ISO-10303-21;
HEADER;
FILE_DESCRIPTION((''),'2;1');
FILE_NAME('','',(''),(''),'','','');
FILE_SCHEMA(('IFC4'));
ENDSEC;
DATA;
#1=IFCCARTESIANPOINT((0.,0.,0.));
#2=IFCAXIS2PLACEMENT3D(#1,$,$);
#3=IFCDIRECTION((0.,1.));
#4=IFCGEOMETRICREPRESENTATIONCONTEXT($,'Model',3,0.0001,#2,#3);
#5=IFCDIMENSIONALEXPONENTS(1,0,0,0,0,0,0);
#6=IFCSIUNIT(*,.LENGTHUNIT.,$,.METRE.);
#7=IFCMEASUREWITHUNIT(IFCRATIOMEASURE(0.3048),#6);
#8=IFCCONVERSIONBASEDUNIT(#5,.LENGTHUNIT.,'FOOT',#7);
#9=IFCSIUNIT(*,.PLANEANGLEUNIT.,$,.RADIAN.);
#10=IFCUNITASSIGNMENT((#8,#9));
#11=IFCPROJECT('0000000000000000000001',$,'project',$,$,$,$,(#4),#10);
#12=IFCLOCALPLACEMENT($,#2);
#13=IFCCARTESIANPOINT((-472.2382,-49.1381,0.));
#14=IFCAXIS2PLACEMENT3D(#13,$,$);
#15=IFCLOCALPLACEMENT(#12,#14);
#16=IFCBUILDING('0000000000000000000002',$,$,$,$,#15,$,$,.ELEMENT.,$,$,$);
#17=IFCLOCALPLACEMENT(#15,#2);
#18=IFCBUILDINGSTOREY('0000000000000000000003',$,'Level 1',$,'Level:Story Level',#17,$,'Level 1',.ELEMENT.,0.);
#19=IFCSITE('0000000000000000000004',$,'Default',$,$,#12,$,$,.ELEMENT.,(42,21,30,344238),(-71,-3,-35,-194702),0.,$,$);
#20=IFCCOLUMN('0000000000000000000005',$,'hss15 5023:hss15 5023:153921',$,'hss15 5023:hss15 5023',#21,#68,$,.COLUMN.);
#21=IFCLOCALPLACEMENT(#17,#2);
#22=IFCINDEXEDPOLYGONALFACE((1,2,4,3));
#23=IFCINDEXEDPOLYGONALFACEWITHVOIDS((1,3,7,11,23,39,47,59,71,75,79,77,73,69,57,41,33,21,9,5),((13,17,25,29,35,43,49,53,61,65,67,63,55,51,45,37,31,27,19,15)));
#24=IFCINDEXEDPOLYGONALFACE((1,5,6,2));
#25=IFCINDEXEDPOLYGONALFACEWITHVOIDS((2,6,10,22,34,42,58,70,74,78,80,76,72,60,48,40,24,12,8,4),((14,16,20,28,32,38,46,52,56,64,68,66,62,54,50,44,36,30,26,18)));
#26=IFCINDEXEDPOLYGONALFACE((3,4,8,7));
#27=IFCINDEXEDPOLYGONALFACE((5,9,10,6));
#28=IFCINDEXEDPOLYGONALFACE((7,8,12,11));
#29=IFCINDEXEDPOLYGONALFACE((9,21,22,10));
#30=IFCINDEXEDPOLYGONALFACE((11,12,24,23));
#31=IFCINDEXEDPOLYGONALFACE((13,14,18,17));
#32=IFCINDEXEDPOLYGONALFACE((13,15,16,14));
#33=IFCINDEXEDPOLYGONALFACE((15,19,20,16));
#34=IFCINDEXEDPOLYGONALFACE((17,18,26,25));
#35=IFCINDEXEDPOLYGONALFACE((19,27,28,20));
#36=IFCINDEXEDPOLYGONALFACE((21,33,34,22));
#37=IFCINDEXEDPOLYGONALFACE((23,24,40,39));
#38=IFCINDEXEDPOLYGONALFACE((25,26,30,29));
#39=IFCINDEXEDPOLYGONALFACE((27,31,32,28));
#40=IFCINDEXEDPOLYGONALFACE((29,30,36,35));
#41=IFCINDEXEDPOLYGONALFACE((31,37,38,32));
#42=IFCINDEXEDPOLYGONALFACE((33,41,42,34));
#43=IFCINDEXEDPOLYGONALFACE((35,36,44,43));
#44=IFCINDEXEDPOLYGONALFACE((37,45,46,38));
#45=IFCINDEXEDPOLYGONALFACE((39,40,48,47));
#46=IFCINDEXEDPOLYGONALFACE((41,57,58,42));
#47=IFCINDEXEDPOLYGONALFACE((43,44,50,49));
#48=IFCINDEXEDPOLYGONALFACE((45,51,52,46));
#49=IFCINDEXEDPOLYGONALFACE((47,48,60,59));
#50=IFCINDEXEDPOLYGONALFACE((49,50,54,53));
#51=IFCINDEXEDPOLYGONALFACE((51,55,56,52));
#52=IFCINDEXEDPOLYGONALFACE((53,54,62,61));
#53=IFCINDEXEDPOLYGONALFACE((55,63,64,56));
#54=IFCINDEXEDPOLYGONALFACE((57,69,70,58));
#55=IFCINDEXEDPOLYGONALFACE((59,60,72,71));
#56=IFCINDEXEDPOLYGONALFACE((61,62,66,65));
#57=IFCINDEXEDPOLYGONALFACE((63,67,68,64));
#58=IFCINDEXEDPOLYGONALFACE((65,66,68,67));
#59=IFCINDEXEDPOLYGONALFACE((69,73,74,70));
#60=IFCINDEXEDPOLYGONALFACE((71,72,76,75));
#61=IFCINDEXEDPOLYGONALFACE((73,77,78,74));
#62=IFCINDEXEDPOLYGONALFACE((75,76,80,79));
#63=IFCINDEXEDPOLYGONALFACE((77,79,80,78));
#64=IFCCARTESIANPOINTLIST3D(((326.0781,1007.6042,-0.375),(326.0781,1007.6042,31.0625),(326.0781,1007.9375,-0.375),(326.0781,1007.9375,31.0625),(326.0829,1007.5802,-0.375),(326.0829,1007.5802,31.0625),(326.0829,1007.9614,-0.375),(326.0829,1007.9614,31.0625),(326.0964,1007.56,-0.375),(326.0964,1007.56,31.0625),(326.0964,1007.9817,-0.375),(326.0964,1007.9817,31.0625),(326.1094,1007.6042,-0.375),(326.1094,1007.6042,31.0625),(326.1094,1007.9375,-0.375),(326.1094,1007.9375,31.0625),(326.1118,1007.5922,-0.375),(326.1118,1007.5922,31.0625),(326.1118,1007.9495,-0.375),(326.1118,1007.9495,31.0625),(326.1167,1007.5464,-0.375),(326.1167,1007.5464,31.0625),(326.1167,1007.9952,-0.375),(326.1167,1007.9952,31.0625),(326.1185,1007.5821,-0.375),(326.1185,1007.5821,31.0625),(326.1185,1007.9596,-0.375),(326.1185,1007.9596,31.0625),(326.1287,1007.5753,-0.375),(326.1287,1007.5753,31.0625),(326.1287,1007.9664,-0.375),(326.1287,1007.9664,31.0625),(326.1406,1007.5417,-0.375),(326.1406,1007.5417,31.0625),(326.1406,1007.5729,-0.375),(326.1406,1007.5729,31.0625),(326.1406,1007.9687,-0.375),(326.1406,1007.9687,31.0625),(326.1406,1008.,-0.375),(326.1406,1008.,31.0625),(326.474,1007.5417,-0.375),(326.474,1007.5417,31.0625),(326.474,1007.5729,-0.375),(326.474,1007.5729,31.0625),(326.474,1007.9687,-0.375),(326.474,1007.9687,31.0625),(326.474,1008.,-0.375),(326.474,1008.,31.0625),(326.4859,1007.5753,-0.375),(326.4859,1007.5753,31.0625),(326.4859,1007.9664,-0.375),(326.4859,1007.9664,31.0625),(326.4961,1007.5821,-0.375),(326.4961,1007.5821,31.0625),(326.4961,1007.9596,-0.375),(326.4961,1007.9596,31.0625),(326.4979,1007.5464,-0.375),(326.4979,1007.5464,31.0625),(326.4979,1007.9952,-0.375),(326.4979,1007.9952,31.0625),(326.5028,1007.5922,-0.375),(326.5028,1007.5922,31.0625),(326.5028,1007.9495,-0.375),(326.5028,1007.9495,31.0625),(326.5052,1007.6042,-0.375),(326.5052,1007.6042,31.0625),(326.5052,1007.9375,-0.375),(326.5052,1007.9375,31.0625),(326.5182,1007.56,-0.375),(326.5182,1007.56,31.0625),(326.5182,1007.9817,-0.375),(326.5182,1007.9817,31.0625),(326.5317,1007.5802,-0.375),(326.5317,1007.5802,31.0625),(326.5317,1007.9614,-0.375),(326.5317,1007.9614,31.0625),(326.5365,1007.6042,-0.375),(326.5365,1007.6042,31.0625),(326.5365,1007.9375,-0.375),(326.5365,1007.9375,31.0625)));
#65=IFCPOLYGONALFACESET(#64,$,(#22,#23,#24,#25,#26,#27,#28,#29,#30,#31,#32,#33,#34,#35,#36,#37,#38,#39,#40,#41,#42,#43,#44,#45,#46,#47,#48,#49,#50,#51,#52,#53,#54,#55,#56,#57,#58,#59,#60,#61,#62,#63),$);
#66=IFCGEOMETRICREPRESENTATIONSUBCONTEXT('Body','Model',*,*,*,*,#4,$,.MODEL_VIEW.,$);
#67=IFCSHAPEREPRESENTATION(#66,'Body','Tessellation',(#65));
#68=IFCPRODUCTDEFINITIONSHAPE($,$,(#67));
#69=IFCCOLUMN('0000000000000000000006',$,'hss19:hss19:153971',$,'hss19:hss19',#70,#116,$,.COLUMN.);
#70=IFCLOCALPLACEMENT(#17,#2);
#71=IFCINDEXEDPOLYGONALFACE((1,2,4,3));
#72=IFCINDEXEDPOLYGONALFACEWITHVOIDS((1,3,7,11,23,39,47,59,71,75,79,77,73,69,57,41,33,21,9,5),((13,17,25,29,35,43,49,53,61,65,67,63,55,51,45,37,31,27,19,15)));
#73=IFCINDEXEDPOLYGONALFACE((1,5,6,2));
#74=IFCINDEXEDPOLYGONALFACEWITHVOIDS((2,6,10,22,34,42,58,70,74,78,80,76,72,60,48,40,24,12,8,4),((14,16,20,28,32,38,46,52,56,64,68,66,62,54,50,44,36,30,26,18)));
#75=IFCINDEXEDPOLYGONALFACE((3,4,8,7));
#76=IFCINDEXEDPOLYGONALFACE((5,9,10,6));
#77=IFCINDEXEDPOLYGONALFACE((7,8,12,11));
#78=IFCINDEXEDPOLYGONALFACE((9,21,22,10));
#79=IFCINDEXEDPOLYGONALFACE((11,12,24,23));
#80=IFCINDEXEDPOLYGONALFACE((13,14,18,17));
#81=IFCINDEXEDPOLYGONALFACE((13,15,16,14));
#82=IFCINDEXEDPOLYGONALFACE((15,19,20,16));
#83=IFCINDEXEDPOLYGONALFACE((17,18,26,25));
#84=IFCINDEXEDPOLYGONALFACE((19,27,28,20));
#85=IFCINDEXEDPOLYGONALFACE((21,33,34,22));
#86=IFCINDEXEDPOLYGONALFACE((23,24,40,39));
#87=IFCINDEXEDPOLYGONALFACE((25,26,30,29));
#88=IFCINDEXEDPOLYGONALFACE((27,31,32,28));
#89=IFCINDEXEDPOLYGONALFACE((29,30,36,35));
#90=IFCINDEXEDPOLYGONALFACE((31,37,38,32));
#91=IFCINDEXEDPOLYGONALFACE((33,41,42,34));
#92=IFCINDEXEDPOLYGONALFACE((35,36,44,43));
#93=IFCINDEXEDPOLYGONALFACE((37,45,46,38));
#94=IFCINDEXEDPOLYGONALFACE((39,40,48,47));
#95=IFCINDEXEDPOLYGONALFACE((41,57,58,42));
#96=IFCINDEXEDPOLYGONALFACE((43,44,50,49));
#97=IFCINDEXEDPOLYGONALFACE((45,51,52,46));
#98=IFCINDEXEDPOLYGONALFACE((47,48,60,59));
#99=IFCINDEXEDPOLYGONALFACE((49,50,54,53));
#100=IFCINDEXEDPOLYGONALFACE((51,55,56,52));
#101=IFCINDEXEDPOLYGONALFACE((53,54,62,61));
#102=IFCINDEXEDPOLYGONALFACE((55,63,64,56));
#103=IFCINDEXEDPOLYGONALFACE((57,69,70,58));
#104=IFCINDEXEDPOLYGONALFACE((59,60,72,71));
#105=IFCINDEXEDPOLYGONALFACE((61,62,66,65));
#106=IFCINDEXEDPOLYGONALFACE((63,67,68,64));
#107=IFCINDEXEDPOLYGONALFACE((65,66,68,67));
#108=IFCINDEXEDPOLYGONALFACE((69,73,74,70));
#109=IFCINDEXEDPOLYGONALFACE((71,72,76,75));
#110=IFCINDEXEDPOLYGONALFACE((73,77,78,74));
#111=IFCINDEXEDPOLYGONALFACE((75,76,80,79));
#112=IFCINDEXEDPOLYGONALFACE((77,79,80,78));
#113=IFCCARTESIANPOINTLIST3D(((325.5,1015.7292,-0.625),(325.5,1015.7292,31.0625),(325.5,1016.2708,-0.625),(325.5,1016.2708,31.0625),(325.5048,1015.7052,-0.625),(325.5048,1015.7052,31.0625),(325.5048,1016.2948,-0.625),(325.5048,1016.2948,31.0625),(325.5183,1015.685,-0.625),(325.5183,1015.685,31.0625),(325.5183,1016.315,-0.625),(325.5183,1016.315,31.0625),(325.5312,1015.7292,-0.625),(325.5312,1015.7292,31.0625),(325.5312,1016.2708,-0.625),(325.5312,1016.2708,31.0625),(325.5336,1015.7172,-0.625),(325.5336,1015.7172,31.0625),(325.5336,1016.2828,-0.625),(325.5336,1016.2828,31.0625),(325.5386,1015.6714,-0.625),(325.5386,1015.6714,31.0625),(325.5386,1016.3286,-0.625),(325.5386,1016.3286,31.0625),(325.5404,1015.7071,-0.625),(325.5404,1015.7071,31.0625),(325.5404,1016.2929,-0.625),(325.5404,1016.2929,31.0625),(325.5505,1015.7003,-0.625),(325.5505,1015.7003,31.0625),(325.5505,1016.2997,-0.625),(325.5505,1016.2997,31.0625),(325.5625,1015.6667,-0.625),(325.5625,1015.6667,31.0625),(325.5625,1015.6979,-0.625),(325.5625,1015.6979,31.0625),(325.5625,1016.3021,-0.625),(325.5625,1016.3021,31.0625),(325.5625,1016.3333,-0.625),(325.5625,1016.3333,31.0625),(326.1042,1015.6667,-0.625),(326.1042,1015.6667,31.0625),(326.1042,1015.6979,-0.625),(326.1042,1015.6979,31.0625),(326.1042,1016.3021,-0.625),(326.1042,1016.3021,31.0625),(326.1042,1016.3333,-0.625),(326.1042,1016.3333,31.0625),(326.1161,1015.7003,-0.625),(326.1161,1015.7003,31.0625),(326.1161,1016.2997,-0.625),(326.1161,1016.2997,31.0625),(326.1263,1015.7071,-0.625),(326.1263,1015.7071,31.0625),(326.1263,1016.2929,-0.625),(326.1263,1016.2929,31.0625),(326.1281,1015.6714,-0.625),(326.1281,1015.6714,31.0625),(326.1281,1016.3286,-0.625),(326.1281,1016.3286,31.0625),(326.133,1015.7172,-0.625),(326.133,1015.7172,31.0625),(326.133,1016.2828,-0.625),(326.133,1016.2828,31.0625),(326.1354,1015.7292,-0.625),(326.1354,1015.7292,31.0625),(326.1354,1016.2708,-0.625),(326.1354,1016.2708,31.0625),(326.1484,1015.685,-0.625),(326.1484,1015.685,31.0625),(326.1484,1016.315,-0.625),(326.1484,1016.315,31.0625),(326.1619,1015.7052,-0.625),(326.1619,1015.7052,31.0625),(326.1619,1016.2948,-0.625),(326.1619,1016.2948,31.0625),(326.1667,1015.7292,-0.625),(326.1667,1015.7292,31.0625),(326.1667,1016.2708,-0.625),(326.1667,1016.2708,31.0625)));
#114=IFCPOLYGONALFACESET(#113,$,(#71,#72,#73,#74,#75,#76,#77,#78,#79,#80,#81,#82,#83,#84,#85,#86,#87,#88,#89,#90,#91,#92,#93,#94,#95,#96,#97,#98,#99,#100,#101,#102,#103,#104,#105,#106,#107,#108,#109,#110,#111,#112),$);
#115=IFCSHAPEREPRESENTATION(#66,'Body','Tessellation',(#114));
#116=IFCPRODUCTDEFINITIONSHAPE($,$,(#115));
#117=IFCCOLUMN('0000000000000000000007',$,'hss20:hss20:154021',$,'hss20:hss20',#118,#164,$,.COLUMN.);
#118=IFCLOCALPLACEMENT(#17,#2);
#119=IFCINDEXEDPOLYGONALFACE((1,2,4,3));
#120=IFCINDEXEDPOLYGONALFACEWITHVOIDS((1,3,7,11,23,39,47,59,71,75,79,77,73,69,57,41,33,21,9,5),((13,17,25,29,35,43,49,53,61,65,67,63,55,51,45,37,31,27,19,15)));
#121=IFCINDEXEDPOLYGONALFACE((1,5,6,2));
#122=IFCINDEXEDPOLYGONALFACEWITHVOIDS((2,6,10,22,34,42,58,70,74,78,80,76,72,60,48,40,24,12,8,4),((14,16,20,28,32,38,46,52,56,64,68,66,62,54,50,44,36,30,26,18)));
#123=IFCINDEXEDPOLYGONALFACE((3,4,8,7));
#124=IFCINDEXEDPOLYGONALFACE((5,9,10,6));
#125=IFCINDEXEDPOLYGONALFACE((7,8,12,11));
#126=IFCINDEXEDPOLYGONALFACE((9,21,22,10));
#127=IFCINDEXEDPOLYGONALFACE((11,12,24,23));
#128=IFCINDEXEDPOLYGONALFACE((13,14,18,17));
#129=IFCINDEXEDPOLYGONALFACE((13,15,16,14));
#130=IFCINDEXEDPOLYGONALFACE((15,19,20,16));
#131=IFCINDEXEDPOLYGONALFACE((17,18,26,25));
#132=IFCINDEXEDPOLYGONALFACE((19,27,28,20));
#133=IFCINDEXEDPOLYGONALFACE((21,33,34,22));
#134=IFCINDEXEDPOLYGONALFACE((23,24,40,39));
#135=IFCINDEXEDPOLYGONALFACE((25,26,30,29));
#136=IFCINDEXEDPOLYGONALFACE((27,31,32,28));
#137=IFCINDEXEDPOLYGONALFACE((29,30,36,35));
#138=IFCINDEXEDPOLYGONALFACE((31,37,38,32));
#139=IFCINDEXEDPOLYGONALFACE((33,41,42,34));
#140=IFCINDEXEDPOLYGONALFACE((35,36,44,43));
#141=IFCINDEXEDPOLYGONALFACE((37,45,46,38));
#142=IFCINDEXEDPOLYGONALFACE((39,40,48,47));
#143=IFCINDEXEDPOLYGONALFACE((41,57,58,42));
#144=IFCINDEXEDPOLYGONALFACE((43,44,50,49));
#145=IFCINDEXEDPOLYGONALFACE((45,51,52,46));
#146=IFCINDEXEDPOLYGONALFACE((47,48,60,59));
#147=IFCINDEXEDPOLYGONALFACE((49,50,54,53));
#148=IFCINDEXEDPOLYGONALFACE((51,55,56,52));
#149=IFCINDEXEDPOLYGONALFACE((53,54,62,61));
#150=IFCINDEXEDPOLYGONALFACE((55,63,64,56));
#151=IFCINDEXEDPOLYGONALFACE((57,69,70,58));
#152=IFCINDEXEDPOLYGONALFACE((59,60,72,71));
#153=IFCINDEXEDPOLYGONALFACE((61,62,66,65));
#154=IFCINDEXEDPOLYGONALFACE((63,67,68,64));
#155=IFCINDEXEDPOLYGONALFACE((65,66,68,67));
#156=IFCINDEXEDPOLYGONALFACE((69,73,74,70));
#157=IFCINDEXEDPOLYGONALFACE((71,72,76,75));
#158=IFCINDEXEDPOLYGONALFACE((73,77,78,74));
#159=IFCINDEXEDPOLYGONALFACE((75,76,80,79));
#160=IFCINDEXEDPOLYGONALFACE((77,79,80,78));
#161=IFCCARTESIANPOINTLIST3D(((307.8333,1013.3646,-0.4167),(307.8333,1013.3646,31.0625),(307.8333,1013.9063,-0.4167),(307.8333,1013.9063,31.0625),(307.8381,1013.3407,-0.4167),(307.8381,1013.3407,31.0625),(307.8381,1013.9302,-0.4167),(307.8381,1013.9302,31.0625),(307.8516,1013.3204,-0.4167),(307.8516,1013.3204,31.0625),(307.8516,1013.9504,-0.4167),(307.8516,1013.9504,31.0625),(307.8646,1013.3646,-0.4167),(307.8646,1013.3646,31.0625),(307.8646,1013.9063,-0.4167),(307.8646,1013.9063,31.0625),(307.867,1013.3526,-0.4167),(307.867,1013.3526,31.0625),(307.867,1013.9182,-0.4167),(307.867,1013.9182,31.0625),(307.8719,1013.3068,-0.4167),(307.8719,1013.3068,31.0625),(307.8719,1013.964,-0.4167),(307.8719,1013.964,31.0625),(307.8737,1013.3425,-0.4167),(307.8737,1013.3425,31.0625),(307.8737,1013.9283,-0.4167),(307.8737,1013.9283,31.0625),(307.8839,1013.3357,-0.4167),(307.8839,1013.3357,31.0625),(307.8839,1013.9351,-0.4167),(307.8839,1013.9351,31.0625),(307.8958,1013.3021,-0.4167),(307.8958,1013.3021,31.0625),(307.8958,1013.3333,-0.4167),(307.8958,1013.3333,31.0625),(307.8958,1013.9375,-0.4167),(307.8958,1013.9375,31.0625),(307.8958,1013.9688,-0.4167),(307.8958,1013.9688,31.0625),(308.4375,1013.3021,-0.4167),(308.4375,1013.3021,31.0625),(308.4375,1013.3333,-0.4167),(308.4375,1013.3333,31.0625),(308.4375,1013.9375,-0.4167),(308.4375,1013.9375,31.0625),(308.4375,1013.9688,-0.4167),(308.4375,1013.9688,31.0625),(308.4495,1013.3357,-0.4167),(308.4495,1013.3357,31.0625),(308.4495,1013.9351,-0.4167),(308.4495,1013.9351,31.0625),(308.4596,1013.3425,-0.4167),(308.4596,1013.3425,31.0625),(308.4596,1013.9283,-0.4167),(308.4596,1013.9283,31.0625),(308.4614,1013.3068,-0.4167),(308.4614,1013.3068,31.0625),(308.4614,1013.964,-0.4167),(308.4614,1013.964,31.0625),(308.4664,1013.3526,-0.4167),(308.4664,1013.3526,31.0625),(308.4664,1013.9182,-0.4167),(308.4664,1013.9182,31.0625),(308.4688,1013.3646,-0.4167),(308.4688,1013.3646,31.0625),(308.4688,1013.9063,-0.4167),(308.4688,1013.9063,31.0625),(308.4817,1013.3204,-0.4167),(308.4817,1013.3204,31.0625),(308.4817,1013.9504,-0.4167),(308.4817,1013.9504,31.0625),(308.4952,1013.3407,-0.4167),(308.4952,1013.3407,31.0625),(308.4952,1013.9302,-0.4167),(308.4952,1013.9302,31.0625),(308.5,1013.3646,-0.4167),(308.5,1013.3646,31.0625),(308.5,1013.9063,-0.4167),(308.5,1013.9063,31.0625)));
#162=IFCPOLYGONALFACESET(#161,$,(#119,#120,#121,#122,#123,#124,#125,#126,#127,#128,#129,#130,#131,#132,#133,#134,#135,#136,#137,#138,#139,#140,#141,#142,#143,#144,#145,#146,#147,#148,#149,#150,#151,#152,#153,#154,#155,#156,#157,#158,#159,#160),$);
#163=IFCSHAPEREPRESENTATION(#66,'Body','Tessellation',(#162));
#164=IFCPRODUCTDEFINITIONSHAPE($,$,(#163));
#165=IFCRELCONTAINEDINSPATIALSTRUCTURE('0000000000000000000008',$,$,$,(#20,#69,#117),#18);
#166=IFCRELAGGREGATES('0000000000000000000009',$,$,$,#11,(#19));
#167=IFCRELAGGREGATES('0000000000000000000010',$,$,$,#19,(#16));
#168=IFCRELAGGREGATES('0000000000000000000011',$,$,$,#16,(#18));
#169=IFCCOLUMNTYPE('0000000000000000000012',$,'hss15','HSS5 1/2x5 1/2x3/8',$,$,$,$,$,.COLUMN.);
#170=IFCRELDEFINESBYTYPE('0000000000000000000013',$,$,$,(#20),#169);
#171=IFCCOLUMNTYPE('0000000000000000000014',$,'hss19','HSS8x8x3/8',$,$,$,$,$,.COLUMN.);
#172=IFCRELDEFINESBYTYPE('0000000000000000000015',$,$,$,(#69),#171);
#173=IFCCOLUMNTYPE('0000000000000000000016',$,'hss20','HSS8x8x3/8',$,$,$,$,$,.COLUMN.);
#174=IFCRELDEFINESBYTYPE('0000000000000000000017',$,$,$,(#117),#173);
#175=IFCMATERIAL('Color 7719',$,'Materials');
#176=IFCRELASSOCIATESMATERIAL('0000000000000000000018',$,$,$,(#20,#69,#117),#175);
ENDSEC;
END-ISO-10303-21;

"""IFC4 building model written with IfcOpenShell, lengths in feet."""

from ifc_helpers import new_model, entity, si_unit, converted_unit, direction, frame, origin, place, context, subcontext, project, spatial, polyline, outline, extrude, boolean, source, transform, mapped, material, type_object, type_shapes, element, save


model = new_model("IFC4")

# Units and contexts
model_context = context("Model", 3, precision=0.0001, world=origin(), true_north=direction((0.0, 1.0)))
body_context = subcontext(model_context, "Body", "Model", "MODEL_VIEW")
ifc_project = project(units=[converted_unit("LENGTHUNIT", "FOOT", entity("IfcRatioMeasure", 0.3048), si_unit("LENGTHUNIT", "METRE"), dimensions=[1, 0, 0, 0, 0, 0, 0]), si_unit("PLANEANGLEUNIT", "RADIAN")], contexts=[model_context])

# Site, building, storey
site_placement = place(None, origin())
site = spatial("IfcSite", under=ifc_project, at=site_placement, Name="Default", CompositionType="ELEMENT", RefLatitude=(42, 21, 30, 344238), RefLongitude=(-71, -3, -35, -194702), RefElevation=0.0)
building_placement = place(site_placement, frame((-472.2382, -49.1381, 0.0)))
building = spatial("IfcBuilding", under=site, at=building_placement, CompositionType="ELEMENT")
storey_placement = place(building_placement, origin())
storey = spatial("IfcBuildingStorey", under=building, at=storey_placement, Name="Level 1", ObjectType="Level:Story Level", LongName="Level 1", CompositionType="ELEMENT", Elevation=0.0)

# Columns
ifc_material_1 = material(Name="Color 7719", Category="Materials")
column_type_1 = type_object("IfcColumnType", Name="hss15", Description="HSS5 1/2x5 1/2x3/8", PredefinedType="COLUMN")
shared_shape_1 = source(origin(), body_context, "Body", "CSG", [
    boolean("DIFFERENCE", extrude(outline(polyline([(-0.1667, -0.2292), (0.1667, -0.2292), (0.1906, -0.2244), (0.2109, -0.2109), (0.2244, -0.1906), (0.2292, -0.1667), (0.2292, 0.1667), (0.2244, 0.1906), (0.2109, 0.2109), (0.1906, 0.2244), (0.1667, 0.2292), (-0.1667, 0.2292), (-0.1906, 0.2244), (-0.2109, 0.2109), (-0.2244, 0.1906), (-0.2292, 0.1667), (-0.2292, -0.1667), (-0.2244, -0.1906), (-0.2109, -0.2109), (-0.1906, -0.2244), (-0.1667, -0.2292)])), frame((326.3073, 1007.7708, -0.375), z_axis=(0.0, 0.0, 1.0), x_axis=(0.0, -1.0, 0.0)), (0.0, 0.0, 1.0), 31.4375), extrude(outline(polyline([(-0.1667, -0.1979), (0.1667, -0.1979), (0.1786, -0.1955), (0.1888, -0.1888), (0.1955, -0.1786), (0.1979, -0.1667), (0.1979, 0.1667), (0.1955, 0.1786), (0.1888, 0.1888), (0.1786, 0.1955), (0.1667, 0.1979), (-0.1667, 0.1979), (-0.1786, 0.1955), (-0.1888, 0.1888), (-0.1955, 0.1786), (-0.1979, 0.1667), (-0.1979, -0.1667), (-0.1955, -0.1786), (-0.1888, -0.1888), (-0.1786, -0.1955), (-0.1667, -0.1979)])), frame((326.3073, 1007.7708, 31.0625), z_axis=(0.0, 0.0, -1.0), x_axis=(0.0, -1.0, 0.0)), (0.0, 0.0, 1.0), 31.4375)),
])
type_shapes(column_type_1, [shared_shape_1])
column_1_placement = place(building_placement, origin())
element("IfcColumn", 1, at=column_1_placement, inside=storey, type_object=column_type_1, material=ifc_material_1, Name="hss15 5023:hss15 5023:153921", ObjectType="hss15 5023:hss15 5023", PredefinedType="COLUMN", context=body_context, shape_type="MappedRepresentation", body=[
    mapped(shared_shape_1, transform((0.0, 0.0, 0.0), scale=1.0)),
])
column_type_2 = type_object("IfcColumnType", Name="hss19", Description="HSS8x8x3/8", PredefinedType="COLUMN")
shared_shape_2 = source(origin(), body_context, "Body", "CSG", [
    boolean("DIFFERENCE", extrude(outline(polyline([(-0.2708, -0.3333), (0.2708, -0.3333), (0.2948, -0.3286), (0.315, -0.315), (0.3286, -0.2948), (0.3333, -0.2708), (0.3333, 0.2708), (0.3286, 0.2948), (0.315, 0.315), (0.2948, 0.3286), (0.2708, 0.3333), (-0.2708, 0.3333), (-0.2948, 0.3286), (-0.315, 0.315), (-0.3286, 0.2948), (-0.3333, 0.2708), (-0.3333, -0.2708), (-0.3286, -0.2948), (-0.315, -0.315), (-0.2948, -0.3286), (-0.2708, -0.3333)])), frame((325.8333, 1016.0, -0.625), z_axis=(0.0, 0.0, 1.0), x_axis=(0.0, -1.0, 0.0)), (0.0, 0.0, 1.0), 31.6875), extrude(outline(polyline([(-0.2708, -0.3021), (0.2708, -0.3021), (0.2828, -0.2997), (0.2929, -0.2929), (0.2997, -0.2828), (0.3021, -0.2708), (0.3021, 0.2708), (0.2997, 0.2828), (0.2929, 0.2929), (0.2828, 0.2997), (0.2708, 0.3021), (-0.2708, 0.3021), (-0.2828, 0.2997), (-0.2929, 0.2929), (-0.2997, 0.2828), (-0.3021, 0.2708), (-0.3021, -0.2708), (-0.2997, -0.2828), (-0.2929, -0.2929), (-0.2828, -0.2997), (-0.2708, -0.3021)])), frame((325.8333, 1016.0, 31.0625), z_axis=(0.0, 0.0, -1.0), x_axis=(0.0, -1.0, 0.0)), (0.0, 0.0, 1.0), 31.6875)),
])
type_shapes(column_type_2, [shared_shape_2])
column_2_placement = place(building_placement, origin())
element("IfcColumn", 2, at=column_2_placement, inside=storey, type_object=column_type_2, material=ifc_material_1, Name="hss19:hss19:153971", ObjectType="hss19:hss19", PredefinedType="COLUMN", context=body_context, shape_type="MappedRepresentation", body=[
    mapped(shared_shape_2, transform((0.0, 0.0, 0.0), scale=1.0)),
])
column_type_3 = type_object("IfcColumnType", Name="hss20", Description="HSS8x8x3/8", PredefinedType="COLUMN")
shared_shape_3 = source(origin(), body_context, "Body", "CSG", [
    boolean("DIFFERENCE", extrude(outline(polyline([(-0.2708, -0.3333), (0.2708, -0.3333), (0.2948, -0.3286), (0.315, -0.315), (0.3286, -0.2948), (0.3333, -0.2708), (0.3333, 0.2708), (0.3286, 0.2948), (0.315, 0.315), (0.2948, 0.3286), (0.2708, 0.3333), (-0.2708, 0.3333), (-0.2948, 0.3286), (-0.315, 0.315), (-0.3286, 0.2948), (-0.3333, 0.2708), (-0.3333, -0.2708), (-0.3286, -0.2948), (-0.315, -0.315), (-0.2948, -0.3286), (-0.2708, -0.3333)])), frame((308.1667, 1013.6354, -0.4167), z_axis=(0.0, 0.0, 1.0), x_axis=(0.0, -1.0, 0.0)), (0.0, 0.0, 1.0), 31.4792), extrude(outline(polyline([(-0.2708, -0.3021), (0.2708, -0.3021), (0.2828, -0.2997), (0.2929, -0.2929), (0.2997, -0.2828), (0.3021, -0.2708), (0.3021, 0.2708), (0.2997, 0.2828), (0.2929, 0.2929), (0.2828, 0.2997), (0.2708, 0.3021), (-0.2708, 0.3021), (-0.2828, 0.2997), (-0.2929, 0.2929), (-0.2997, 0.2828), (-0.3021, 0.2708), (-0.3021, -0.2708), (-0.2997, -0.2828), (-0.2929, -0.2929), (-0.2828, -0.2997), (-0.2708, -0.3021)])), frame((308.1667, 1013.6354, 31.0625), z_axis=(0.0, 0.0, -1.0), x_axis=(0.0, -1.0, 0.0)), (0.0, 0.0, 1.0), 31.4792)),
])
type_shapes(column_type_3, [shared_shape_3])
column_3_placement = place(building_placement, origin())
element("IfcColumn", 3, at=column_3_placement, inside=storey, type_object=column_type_3, material=ifc_material_1, Name="hss20:hss20:154021", ObjectType="hss20:hss20", PredefinedType="COLUMN", context=body_context, shape_type="MappedRepresentation", body=[
    mapped(shared_shape_3, transform((0.0, 0.0, 0.0), scale=1.0)),
])

save(model, "model.ifc")
